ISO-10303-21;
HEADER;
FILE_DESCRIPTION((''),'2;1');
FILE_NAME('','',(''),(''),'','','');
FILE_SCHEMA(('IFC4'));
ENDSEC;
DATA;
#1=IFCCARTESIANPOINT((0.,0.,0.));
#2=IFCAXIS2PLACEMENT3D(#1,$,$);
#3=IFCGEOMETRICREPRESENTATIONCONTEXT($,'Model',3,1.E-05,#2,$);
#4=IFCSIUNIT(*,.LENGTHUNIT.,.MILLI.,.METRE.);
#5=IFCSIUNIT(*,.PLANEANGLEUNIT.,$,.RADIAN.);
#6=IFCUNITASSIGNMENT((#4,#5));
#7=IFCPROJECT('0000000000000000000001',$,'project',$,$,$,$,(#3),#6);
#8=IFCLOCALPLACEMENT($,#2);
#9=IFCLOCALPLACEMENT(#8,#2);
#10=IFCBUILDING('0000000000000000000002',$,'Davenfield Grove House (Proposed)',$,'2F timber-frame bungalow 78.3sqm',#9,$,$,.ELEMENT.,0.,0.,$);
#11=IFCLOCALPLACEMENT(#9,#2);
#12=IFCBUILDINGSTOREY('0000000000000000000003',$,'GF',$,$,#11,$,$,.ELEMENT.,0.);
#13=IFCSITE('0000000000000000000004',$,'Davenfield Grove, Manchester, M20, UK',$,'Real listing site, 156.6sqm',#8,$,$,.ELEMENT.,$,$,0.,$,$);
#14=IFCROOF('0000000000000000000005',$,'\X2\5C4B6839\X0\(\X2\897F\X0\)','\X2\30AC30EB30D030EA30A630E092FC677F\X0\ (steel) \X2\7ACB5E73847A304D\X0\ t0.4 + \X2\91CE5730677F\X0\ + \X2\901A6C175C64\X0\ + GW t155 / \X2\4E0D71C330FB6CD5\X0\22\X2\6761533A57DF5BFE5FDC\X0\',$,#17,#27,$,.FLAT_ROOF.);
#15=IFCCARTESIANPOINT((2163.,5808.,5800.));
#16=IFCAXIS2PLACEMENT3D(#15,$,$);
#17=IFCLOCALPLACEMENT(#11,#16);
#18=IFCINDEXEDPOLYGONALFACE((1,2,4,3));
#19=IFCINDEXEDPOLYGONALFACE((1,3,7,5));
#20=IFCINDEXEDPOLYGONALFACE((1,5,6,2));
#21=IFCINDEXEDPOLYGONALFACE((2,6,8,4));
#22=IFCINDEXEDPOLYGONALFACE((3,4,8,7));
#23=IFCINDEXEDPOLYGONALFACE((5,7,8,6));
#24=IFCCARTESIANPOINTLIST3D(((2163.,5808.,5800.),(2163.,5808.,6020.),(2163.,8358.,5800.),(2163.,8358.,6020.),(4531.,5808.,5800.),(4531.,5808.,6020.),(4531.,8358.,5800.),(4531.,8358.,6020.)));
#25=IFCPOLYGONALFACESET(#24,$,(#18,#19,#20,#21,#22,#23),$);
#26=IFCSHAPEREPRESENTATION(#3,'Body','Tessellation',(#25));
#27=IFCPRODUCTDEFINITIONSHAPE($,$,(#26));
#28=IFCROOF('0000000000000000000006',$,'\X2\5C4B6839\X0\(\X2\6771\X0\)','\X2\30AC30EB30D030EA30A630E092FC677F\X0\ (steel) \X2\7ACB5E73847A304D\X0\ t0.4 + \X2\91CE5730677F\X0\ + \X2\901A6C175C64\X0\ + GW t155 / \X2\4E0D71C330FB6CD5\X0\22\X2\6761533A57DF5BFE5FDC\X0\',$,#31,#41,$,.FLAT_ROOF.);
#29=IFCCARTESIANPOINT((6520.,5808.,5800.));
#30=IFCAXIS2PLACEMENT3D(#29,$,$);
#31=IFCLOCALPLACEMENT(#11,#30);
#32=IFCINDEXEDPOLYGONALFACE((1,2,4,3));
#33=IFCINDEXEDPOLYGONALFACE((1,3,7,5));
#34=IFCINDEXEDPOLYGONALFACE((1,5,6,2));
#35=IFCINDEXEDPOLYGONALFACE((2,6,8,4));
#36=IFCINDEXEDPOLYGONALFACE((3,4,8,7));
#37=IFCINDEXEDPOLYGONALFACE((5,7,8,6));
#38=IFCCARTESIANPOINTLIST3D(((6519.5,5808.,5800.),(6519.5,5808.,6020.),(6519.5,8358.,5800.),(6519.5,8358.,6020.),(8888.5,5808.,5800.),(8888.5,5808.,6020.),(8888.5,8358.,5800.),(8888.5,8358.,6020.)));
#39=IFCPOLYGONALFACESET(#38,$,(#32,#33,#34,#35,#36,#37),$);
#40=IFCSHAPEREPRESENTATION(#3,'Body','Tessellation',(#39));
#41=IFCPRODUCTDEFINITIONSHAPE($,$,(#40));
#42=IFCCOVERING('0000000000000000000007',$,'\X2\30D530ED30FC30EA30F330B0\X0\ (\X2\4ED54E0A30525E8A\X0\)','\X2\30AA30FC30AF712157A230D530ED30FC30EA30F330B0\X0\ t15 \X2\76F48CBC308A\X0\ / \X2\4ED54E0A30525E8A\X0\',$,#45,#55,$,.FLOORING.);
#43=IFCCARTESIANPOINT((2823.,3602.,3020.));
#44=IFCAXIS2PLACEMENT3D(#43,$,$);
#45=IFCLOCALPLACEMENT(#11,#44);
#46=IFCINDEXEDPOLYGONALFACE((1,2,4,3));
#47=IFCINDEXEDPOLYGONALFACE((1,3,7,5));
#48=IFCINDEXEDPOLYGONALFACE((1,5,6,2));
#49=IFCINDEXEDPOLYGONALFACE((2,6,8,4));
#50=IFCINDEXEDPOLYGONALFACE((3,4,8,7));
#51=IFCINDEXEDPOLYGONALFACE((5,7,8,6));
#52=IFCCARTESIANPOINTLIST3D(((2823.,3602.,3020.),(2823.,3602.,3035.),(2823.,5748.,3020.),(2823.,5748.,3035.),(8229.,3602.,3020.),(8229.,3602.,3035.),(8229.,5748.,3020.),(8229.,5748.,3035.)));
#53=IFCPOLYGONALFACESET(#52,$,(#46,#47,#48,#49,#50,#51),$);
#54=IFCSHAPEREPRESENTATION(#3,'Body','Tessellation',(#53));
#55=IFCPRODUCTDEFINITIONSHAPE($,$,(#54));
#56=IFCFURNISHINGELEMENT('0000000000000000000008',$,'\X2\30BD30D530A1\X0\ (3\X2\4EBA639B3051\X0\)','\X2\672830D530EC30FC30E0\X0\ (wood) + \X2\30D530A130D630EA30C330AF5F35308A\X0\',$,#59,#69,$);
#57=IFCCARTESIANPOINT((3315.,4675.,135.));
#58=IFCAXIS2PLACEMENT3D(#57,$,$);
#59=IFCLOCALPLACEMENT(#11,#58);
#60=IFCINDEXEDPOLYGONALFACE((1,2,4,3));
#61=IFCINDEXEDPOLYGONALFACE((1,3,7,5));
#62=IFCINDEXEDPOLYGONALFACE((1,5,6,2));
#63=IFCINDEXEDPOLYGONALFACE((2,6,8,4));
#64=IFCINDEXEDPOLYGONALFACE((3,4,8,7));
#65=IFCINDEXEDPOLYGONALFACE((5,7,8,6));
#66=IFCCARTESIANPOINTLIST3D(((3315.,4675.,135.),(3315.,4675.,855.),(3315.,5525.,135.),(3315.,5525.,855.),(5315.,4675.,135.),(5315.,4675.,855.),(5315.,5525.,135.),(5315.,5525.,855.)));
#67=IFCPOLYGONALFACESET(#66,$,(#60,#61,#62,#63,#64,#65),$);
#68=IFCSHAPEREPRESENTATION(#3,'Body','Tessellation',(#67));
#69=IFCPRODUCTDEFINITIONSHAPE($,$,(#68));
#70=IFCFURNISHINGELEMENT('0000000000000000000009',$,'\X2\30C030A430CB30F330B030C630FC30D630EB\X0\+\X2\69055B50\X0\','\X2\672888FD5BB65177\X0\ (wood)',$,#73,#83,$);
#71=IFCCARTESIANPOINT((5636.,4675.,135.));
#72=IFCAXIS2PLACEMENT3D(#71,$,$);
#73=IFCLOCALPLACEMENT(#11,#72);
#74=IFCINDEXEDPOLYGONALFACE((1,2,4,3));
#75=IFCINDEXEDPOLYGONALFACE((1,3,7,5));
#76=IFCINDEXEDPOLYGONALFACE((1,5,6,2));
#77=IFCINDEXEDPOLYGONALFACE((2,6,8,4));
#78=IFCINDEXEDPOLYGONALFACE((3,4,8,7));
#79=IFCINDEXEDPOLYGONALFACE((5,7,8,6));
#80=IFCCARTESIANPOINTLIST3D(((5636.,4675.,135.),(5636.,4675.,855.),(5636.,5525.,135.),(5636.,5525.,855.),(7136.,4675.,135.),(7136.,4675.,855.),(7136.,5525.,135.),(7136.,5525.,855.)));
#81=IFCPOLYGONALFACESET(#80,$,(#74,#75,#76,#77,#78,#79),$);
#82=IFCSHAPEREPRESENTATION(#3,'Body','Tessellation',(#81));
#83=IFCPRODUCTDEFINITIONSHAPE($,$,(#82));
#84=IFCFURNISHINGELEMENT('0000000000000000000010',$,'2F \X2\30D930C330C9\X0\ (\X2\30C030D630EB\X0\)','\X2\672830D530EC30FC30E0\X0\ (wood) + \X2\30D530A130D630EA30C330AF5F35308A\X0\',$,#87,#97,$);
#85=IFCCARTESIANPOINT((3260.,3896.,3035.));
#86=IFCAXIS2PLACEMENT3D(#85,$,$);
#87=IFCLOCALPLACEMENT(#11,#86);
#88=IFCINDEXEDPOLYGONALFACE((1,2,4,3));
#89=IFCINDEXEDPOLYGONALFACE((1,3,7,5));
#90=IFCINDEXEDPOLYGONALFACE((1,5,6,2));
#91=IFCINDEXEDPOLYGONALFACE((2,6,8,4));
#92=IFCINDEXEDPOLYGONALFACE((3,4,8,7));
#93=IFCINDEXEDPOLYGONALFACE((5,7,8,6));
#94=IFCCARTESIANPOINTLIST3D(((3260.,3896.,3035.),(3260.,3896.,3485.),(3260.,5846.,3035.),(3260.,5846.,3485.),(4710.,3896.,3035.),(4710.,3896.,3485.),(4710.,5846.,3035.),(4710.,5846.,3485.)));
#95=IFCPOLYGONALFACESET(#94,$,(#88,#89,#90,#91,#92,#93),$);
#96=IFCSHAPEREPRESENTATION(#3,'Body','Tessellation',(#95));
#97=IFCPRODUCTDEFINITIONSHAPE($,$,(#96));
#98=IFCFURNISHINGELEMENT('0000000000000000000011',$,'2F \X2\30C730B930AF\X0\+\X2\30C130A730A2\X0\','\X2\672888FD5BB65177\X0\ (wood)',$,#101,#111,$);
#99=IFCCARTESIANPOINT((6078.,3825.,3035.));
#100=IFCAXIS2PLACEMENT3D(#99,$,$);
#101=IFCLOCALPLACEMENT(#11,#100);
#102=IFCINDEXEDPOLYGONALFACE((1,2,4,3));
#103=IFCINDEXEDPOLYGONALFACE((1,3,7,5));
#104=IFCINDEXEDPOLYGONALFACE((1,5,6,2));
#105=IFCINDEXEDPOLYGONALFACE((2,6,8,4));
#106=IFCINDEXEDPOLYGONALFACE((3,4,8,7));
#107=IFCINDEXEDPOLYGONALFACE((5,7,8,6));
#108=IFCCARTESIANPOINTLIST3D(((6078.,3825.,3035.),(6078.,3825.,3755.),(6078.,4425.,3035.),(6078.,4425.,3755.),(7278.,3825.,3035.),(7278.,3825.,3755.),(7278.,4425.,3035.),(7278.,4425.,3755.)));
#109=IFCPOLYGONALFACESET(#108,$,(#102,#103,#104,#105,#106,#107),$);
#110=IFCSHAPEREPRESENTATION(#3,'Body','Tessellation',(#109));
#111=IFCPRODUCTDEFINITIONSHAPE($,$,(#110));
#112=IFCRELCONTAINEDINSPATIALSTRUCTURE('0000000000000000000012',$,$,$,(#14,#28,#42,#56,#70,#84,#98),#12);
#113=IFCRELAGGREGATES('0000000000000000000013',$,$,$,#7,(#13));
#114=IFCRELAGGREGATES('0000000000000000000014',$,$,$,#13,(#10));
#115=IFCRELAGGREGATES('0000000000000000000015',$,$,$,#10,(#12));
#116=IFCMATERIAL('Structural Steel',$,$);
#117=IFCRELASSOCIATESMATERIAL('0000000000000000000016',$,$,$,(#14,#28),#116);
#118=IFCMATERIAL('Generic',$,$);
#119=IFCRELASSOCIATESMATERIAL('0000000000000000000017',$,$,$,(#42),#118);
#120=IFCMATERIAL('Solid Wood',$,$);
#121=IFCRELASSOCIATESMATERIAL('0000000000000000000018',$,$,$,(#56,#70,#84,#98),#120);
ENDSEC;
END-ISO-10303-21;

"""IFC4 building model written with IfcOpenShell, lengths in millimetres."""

from ifc_helpers import new_model, si_unit, frame, frame_2d, origin, place, context, project, spatial, rectangle, extrude, material, element, save


model = new_model("IFC4")

# Units and contexts
model_context = context("Model", 3, precision=1e-05, world=origin())
ifc_project = project(units=[si_unit("LENGTHUNIT", "METRE", prefix="MILLI"), si_unit("PLANEANGLEUNIT", "RADIAN")], contexts=[model_context])

# Site, building, storey
site_placement = place(None, origin())
site = spatial("IfcSite", under=ifc_project, at=site_placement, Name="Davenfield Grove, Manchester, M20, UK", ObjectType="Real listing site, 156.6sqm", CompositionType="ELEMENT", RefElevation=0.0)
building_placement = place(site_placement, origin())
building = spatial("IfcBuilding", under=site, at=building_placement, Name="Davenfield Grove House (Proposed)", ObjectType="2F timber-frame bungalow 78.3sqm", CompositionType="ELEMENT", ElevationOfRefHeight=0.0, ElevationOfTerrain=0.0)
storey_placement = place(building_placement, origin())
storey = spatial("IfcBuildingStorey", under=building, at=storey_placement, Name="GF", CompositionType="ELEMENT", Elevation=0.0)

# Shared definitions
ifc_material_1 = material(Name="Solid Wood")

# Roofs
ifc_material_2 = material(Name="Structural Steel")
roof_1_placement = place(storey_placement, frame((2163.0, 5808.0, 5800.0)))
element("IfcRoof", 1, at=roof_1_placement, inside=storey, material=ifc_material_2, Name="屋根(西)", Description="ガルバリウム鋼板 (steel) 立平葺き t0.4 + 野地板 + 通気層 + GW t155 / 不燃・法22条区域対応", PredefinedType="FLAT_ROOF", context=model_context, shape_type="SweptSolid", body=[
    extrude(rectangle(XDim=2368.0, YDim=2550.0, at=frame_2d((1184.0, 1275.0))), frame((2163.0, 5808.0, 5800.0)), (0.0, 0.0, 1.0), 220.0),
])
roof_2_placement = place(storey_placement, frame((6520.0, 5808.0, 5800.0)))
element("IfcRoof", 2, at=roof_2_placement, inside=storey, material=ifc_material_2, Name="屋根(東)", Description="ガルバリウム鋼板 (steel) 立平葺き t0.4 + 野地板 + 通気層 + GW t155 / 不燃・法22条区域対応", PredefinedType="FLAT_ROOF", context=model_context, shape_type="SweptSolid", body=[
    extrude(rectangle(XDim=2369.0, YDim=2550.0, at=frame_2d((1184.0, 1275.0))), frame((6520.0, 5808.0, 5800.0)), (0.0, 0.0, 1.0), 220.0),
])

# Covering
ifc_material_3 = material(Name="Generic")
covering_placement = place(storey_placement, frame((2823.0, 3602.0, 3020.0)))
element("IfcCovering", 3, at=covering_placement, inside=storey, material=ifc_material_3, Name="フローリング (仕上げ床)", Description="オーク無垢フローリング t15 直貼り / 仕上げ床", PredefinedType="FLOORING", context=model_context, shape_type="SweptSolid", body=[
    extrude(rectangle(XDim=5406.0, YDim=2146.0, at=frame_2d((2703.0, 1073.0))), frame((2823.0, 3602.0, 3020.0)), (0.0, 0.0, 1.0), 15.0),
])

# Furnishing elements
furnishing_1_placement = place(storey_placement, frame((3315.0, 4675.0, 135.0)))
element("IfcFurnishingElement", 4, at=furnishing_1_placement, inside=storey, material=ifc_material_1, Name="ソファ (3人掛け)", Description="木フレーム (wood) + ファブリック張り", context=model_context, shape_type="SweptSolid", body=[
    extrude(rectangle(XDim=2000.0, YDim=850.0, at=frame_2d((1000.0, 425.0))), frame((3315.0, 4675.0, 135.0)), (0.0, 0.0, 1.0), 720.0),
])
furnishing_2_placement = place(storey_placement, frame((5636.0, 4675.0, 135.0)))
element("IfcFurnishingElement", 5, at=furnishing_2_placement, inside=storey, material=ifc_material_1, Name="ダイニングテーブル+椅子", Description="木製家具 (wood)", context=model_context, shape_type="SweptSolid", body=[
    extrude(rectangle(XDim=1500.0, YDim=850.0, at=frame_2d((750.0, 425.0))), frame((5636.0, 4675.0, 135.0)), (0.0, 0.0, 1.0), 720.0),
])
furnishing_3_placement = place(storey_placement, frame((3260.0, 3896.0, 3035.0)))
element("IfcFurnishingElement", 6, at=furnishing_3_placement, inside=storey, material=ifc_material_1, Name="2F ベッド (ダブル)", Description="木フレーム (wood) + ファブリック張り", context=model_context, shape_type="SweptSolid", body=[
    extrude(rectangle(XDim=1450.0, YDim=1950.0, at=frame_2d((725.0, 975.0))), frame((3260.0, 3896.0, 3035.0)), (0.0, 0.0, 1.0), 450.0),
])
furnishing_4_placement = place(storey_placement, frame((6078.0, 3825.0, 3035.0)))
element("IfcFurnishingElement", 7, at=furnishing_4_placement, inside=storey, material=ifc_material_1, Name="2F デスク+チェア", Description="木製家具 (wood)", context=model_context, shape_type="SweptSolid", body=[
    extrude(rectangle(XDim=1200.0, YDim=600.0, at=frame_2d((600.0, 300.0))), frame((6078.0, 3825.0, 3035.0)), (0.0, 0.0, 1.0), 720.0),
])

save(model, "model.ifc")
